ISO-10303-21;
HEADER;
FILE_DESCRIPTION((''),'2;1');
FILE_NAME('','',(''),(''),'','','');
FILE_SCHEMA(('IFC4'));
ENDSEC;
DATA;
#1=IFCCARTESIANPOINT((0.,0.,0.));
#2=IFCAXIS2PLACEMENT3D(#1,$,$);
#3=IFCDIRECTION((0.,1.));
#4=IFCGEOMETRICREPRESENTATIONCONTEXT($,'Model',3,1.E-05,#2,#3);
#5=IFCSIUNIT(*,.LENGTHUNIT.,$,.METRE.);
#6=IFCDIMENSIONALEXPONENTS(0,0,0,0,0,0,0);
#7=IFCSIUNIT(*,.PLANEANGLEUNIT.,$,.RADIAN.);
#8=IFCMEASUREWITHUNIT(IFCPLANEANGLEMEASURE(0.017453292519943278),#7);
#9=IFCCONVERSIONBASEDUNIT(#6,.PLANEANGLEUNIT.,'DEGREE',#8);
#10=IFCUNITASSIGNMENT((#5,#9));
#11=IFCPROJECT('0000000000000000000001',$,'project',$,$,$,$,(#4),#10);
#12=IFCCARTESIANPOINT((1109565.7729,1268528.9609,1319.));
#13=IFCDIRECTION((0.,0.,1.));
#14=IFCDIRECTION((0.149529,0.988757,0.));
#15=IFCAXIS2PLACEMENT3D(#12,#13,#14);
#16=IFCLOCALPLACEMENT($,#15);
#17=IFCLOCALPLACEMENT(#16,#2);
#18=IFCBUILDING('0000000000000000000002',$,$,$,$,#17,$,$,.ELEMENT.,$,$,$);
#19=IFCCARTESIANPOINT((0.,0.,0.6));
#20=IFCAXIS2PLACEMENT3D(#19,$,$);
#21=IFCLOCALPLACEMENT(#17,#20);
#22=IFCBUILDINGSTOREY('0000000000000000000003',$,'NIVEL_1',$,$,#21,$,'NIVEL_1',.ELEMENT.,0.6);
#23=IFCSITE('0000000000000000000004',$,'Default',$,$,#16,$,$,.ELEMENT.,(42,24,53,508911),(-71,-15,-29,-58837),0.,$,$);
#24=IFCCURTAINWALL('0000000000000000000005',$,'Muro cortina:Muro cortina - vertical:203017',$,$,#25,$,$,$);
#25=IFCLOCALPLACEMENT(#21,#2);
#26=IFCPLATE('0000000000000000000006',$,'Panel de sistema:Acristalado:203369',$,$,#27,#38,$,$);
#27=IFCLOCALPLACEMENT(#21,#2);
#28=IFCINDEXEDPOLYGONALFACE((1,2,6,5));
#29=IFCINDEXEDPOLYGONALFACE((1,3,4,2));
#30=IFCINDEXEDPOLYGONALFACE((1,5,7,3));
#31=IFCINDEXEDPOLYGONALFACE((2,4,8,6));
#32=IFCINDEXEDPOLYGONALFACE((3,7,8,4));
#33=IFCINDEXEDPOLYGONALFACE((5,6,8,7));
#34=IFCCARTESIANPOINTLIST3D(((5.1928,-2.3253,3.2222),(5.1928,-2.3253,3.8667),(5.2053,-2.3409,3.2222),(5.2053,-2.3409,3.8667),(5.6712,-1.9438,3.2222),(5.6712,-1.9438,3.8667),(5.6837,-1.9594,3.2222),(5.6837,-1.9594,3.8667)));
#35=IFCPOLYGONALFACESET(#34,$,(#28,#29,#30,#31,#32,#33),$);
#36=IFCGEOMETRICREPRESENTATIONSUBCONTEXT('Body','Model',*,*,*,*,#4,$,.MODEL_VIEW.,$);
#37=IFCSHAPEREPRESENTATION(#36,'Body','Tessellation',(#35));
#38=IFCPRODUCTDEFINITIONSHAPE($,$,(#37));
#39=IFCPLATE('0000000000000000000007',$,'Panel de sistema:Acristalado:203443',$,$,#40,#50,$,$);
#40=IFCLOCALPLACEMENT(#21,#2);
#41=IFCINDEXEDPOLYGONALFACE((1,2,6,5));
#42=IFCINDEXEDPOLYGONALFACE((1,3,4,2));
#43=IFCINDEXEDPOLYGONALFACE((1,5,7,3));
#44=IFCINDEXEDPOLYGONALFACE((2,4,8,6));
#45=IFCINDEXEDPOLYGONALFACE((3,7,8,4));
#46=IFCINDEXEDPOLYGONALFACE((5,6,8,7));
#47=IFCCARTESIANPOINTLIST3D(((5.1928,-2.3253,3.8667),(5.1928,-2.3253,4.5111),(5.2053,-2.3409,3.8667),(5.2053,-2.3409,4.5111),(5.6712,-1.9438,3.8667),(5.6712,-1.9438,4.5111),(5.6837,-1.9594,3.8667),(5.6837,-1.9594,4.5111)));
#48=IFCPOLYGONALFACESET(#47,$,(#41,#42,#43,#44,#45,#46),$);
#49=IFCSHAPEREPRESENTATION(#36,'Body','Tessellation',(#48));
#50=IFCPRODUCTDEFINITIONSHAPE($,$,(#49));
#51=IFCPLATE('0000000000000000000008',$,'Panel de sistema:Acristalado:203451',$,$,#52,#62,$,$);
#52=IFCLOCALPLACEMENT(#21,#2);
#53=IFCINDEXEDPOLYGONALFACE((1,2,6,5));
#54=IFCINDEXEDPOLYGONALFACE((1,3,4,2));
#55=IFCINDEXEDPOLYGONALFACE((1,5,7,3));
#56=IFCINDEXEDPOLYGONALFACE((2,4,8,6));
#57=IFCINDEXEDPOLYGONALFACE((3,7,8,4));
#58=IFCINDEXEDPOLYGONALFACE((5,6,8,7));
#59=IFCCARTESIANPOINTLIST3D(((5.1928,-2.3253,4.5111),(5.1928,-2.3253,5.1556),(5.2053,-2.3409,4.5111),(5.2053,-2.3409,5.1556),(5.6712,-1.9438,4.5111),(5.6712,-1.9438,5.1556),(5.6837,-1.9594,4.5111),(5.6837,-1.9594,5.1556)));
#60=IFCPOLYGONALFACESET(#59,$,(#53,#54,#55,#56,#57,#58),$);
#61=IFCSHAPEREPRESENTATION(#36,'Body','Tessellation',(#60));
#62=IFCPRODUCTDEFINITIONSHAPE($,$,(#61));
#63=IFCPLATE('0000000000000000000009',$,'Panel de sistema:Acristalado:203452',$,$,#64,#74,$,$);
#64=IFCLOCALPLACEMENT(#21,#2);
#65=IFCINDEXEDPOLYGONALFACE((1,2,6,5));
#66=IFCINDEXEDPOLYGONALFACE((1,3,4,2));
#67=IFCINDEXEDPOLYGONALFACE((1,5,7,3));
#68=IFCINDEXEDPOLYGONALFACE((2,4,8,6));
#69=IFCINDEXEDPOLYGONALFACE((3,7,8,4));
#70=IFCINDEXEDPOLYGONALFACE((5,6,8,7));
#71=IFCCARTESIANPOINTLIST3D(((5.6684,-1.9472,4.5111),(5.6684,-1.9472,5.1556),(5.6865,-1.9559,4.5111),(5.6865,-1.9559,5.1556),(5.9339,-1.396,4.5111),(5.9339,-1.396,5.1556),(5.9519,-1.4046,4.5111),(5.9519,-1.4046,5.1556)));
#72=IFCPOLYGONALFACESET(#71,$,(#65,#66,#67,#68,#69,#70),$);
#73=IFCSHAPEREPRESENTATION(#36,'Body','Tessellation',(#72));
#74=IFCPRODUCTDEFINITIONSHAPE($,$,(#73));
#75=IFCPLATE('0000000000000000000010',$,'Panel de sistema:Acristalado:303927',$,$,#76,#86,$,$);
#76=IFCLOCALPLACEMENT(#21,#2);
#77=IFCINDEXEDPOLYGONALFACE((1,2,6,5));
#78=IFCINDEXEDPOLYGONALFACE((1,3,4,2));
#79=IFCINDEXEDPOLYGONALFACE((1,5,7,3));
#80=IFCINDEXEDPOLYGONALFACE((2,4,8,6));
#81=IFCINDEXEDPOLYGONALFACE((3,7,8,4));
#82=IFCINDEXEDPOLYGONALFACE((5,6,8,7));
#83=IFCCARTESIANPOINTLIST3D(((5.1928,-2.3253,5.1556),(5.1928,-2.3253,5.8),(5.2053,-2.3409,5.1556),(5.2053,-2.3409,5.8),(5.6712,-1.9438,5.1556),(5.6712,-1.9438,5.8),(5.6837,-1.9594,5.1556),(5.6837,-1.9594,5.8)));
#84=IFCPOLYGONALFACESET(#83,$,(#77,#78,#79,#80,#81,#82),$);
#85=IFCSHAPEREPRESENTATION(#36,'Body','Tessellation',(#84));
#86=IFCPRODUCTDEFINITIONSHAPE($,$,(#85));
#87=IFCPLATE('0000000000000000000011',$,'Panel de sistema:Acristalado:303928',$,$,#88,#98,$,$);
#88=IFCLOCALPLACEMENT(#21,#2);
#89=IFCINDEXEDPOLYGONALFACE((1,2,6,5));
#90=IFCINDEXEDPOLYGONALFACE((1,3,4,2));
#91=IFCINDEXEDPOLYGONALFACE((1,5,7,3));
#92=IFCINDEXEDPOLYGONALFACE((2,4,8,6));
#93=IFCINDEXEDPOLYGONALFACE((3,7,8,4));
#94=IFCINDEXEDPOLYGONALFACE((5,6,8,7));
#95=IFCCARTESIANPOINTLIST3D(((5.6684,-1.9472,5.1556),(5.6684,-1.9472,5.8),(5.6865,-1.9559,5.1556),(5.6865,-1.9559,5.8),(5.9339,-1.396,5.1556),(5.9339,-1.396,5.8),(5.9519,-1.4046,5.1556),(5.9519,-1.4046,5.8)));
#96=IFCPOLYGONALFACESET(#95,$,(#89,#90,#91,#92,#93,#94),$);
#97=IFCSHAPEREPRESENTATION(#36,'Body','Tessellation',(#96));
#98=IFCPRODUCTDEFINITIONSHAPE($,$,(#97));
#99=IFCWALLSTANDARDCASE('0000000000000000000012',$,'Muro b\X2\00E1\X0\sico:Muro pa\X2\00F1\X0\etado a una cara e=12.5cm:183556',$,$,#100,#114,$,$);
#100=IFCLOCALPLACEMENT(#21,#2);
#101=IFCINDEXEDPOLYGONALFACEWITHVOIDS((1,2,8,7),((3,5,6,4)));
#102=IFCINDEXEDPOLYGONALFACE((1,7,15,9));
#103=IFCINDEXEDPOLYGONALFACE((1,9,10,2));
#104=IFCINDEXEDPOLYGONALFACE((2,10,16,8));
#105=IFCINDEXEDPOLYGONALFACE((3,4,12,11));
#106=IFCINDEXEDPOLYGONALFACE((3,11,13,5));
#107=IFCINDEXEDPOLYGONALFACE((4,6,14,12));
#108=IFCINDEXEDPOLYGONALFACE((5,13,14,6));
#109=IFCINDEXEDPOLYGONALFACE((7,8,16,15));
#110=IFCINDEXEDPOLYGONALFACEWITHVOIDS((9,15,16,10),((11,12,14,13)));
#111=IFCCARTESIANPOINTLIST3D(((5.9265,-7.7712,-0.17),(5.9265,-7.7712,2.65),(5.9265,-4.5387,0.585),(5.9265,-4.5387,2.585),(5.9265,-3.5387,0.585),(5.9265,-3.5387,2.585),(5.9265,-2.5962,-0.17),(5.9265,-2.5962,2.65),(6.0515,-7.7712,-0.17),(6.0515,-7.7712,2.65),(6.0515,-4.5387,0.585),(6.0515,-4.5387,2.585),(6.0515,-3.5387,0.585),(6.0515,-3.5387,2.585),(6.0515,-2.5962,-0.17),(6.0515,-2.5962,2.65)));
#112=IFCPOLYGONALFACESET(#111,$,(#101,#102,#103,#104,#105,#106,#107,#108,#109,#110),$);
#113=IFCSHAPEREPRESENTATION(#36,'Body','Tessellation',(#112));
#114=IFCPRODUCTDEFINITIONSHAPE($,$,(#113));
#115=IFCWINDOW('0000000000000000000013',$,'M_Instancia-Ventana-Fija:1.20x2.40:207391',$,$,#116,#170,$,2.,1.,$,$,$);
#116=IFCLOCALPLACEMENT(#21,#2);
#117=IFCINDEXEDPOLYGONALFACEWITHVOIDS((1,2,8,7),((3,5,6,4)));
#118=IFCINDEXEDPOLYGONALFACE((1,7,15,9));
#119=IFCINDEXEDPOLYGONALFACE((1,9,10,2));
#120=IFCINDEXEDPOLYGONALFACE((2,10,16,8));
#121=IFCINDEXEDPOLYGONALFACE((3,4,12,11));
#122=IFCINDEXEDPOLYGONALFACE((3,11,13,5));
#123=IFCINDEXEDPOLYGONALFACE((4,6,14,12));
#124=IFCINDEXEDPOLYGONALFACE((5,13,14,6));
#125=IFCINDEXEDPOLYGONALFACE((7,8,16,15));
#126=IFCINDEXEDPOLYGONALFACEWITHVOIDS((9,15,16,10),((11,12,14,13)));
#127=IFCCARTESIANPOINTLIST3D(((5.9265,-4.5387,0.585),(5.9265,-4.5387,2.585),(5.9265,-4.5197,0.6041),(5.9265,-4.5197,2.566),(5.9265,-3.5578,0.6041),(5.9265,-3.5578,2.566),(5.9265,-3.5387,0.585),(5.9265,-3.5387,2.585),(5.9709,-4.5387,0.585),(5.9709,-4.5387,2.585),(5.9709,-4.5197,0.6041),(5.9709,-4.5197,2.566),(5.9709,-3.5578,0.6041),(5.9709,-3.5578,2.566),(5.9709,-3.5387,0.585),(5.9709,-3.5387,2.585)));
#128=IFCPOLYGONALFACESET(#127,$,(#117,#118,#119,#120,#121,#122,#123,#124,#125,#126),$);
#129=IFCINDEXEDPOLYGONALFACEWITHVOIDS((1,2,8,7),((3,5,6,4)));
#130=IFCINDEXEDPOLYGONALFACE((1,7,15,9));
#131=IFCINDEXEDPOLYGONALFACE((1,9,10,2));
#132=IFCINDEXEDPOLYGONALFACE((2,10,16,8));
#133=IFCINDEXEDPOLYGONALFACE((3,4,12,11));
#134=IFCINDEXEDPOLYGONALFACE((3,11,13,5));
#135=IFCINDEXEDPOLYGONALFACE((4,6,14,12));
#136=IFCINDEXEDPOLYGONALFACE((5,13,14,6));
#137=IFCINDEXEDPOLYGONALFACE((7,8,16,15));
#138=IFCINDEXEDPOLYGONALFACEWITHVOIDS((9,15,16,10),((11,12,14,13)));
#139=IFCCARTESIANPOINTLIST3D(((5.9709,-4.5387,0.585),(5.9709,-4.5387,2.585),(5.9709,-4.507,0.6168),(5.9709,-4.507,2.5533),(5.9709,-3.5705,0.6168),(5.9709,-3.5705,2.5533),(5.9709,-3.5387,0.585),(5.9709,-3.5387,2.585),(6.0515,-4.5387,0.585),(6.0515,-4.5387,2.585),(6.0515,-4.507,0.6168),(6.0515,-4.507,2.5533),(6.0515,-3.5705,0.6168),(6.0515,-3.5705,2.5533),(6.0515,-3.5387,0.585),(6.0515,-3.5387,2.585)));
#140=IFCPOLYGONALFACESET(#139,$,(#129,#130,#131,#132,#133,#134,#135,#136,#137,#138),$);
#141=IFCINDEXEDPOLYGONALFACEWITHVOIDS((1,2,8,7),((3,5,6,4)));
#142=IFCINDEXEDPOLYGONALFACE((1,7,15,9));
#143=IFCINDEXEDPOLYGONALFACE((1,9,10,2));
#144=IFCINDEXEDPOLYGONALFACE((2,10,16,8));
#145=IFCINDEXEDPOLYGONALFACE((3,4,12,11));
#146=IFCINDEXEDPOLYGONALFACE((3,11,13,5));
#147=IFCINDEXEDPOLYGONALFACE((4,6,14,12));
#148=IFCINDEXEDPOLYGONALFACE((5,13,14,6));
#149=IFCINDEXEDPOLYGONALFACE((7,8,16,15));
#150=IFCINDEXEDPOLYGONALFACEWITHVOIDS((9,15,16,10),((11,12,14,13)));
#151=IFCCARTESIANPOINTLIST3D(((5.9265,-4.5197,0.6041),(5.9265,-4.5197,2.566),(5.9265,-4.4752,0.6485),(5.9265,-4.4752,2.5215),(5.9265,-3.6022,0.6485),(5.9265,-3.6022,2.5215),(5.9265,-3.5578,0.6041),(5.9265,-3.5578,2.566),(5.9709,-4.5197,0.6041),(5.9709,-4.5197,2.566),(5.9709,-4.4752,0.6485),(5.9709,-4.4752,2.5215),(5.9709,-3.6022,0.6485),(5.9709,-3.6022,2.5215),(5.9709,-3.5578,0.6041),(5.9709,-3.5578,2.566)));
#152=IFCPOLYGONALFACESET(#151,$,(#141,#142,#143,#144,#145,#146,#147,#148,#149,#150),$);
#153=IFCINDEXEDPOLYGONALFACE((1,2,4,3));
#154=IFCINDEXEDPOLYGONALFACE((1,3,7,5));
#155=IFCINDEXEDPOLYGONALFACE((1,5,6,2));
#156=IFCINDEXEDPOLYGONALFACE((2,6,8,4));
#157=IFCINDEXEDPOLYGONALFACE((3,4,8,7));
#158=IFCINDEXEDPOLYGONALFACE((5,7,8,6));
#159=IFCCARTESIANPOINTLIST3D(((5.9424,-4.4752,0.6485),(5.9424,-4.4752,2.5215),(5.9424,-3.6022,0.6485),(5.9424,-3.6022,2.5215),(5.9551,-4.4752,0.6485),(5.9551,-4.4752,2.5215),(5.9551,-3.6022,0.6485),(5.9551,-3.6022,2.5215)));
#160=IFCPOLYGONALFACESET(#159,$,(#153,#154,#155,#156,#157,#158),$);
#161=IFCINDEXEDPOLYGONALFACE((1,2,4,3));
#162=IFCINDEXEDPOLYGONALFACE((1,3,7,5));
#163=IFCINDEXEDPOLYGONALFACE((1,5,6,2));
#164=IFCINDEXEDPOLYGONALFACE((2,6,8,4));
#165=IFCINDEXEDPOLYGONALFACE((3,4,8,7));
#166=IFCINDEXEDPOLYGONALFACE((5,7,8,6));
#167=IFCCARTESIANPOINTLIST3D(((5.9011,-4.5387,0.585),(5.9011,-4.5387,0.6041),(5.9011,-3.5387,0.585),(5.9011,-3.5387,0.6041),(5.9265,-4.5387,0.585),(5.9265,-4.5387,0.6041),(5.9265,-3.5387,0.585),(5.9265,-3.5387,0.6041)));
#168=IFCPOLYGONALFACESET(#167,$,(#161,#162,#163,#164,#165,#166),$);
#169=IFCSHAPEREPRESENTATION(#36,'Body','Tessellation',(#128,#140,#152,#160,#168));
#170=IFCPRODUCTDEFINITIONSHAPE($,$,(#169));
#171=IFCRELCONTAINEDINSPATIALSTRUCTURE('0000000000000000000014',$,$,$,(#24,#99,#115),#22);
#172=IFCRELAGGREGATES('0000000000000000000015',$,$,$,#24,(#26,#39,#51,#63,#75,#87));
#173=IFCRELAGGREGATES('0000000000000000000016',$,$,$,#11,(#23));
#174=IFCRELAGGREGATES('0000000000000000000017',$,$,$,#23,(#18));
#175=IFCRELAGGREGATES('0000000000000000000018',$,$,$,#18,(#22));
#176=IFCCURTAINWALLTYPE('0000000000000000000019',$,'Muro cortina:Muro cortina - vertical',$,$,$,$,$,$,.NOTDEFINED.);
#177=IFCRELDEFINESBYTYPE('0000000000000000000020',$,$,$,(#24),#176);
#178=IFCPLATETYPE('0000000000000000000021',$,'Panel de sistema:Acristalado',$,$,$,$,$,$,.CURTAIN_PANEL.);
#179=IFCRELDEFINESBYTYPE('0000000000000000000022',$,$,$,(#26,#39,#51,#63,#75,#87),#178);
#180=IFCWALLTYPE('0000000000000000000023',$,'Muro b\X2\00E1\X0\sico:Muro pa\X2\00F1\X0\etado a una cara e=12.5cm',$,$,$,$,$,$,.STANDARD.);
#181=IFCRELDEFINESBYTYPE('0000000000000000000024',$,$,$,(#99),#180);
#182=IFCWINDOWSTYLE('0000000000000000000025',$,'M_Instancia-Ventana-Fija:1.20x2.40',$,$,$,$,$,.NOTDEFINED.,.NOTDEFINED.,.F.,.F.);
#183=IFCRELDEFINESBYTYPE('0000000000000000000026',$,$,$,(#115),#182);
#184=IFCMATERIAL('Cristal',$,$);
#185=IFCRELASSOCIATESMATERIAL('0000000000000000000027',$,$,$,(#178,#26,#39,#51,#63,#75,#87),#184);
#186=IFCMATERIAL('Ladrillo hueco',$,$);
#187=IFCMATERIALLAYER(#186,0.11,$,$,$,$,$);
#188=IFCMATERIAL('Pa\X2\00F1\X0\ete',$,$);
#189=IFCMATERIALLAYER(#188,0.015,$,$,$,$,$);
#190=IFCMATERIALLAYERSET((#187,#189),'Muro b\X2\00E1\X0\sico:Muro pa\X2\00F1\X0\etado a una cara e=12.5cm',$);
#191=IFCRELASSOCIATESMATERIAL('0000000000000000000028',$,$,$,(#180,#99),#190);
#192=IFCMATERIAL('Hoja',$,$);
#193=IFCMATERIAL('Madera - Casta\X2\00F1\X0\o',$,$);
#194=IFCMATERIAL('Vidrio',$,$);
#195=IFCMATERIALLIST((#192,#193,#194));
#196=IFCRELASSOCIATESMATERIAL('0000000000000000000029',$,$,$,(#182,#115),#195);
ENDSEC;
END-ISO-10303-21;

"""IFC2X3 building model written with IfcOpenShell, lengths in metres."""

from ifc_helpers import new_model, entity, si_unit, converted_unit, direction, frame, frame_2d, origin, origin_2d_with_axis, place, context, subcontext, project, spatial, polyline, rectangle, outline, extrude, source, transform, mapped, material, material_list, layer, layer_set, layer_usage, type_object, type_shapes, element, fill, aggregate, save


model = new_model("IFC2X3")

# Units and contexts
model_context = context("Model", 3, precision=1e-05, world=origin(), true_north=direction((0.0, 1.0)))
body_context = subcontext(model_context, "Body", "Model", "MODEL_VIEW")
ifc_project = project(units=[si_unit("LENGTHUNIT", "METRE"), converted_unit("PLANEANGLEUNIT", "DEGREE", entity("IfcPlaneAngleMeasure", 0.017453292519943278), si_unit("PLANEANGLEUNIT", "RADIAN"), dimensions=[0, 0, 0, 0, 0, 0, 0])], contexts=[model_context])

# Site, building, storey
site_placement = place(None, frame((1109565.7729, 1268528.9609, 1319.0), z_axis=(0.0, 0.0, 1.0), x_axis=(0.149529, 0.988757, 0.0)))
site = spatial("IfcSite", under=ifc_project, at=site_placement, Name="Default", CompositionType="ELEMENT", RefLatitude=(42, 24, 53, 508911), RefLongitude=(-71, -15, -29, -58837), RefElevation=0.0)
building_placement = place(site_placement, origin())
building = spatial("IfcBuilding", under=site, at=building_placement, CompositionType="ELEMENT")
storey_placement = place(building_placement, frame((0.0, 0.0, 0.6)))
storey = spatial("IfcBuildingStorey", under=building, at=storey_placement, Name="NIVEL_1", LongName="NIVEL_1", CompositionType="ELEMENT", Elevation=0.6)

# Curtain wall, plates
curtain_wall_type = type_object("IfcCurtainWallType", Name="Muro cortina:Muro cortina - vertical", PredefinedType="NOTDEFINED")
curtain_wall_1_placement = place(storey_placement, frame((0.0, 0.0, -0.6)))
curtain_wall_1 = element("IfcCurtainWall", 1, at=curtain_wall_1_placement, inside=storey, type_object=curtain_wall_type, Name="Muro cortina:Muro cortina - vertical:203017")
ifc_material_1 = material(Name="Cristal")
plate_type_1 = type_object("IfcPlateType", Name="Panel de sistema:Acristalado", PredefinedType="CURTAIN_PANEL", material=ifc_material_1)
shared_shape_1 = source(origin(), body_context, "Body", "SweptSolid", [
    extrude(rectangle(XDim=0.02, YDim=0.6119, at=frame_2d((0.0, 0.0), x_axis=(1.0, 0.0))), frame((0.0, 0.0, 0.0), z_axis=(0.0, 0.0, 1.0), x_axis=(0.0, 1.0, 0.0)), (0.0, 0.0, 1.0), 0.6444),
])
type_shapes(plate_type_1, [shared_shape_1])
plate_1_placement = place(curtain_wall_1_placement, frame((5.4383, -2.1423, 3.8222), z_axis=(0.0, 0.0, 1.0), x_axis=(0.781832, 0.62349, 0.0)))
plate_1 = element("IfcPlate", 2, at=plate_1_placement, type_object=plate_type_1, material=ifc_material_1, Name="Panel de sistema:Acristalado:203369", context=body_context, shape_type="MappedRepresentation", body=[
    mapped(shared_shape_1, transform((0.0, 0.0, 0.0), scale=1.0)),
])
plate_2_placement = place(curtain_wall_1_placement, frame((5.4383, -2.1423, 4.4667), z_axis=(0.0, 0.0, 1.0), x_axis=(0.781832, 0.62349, 0.0)))
plate_2 = element("IfcPlate", 3, at=plate_2_placement, type_object=plate_type_1, material=ifc_material_1, Name="Panel de sistema:Acristalado:203443", context=body_context, shape_type="MappedRepresentation", body=[
    mapped(shared_shape_1, transform((0.0, 0.0, 0.0), scale=1.0)),
])
plate_3_placement = place(curtain_wall_1_placement, frame((5.4383, -2.1423, 5.1111), z_axis=(0.0, 0.0, 1.0), x_axis=(0.781832, 0.62349, 0.0)))
plate_3 = element("IfcPlate", 4, at=plate_3_placement, type_object=plate_type_1, material=ifc_material_1, Name="Panel de sistema:Acristalado:203451", context=body_context, shape_type="MappedRepresentation", body=[
    mapped(shared_shape_1, transform((0.0, 0.0, 0.0), scale=1.0)),
])
plate_4_placement = place(curtain_wall_1_placement, frame((5.8102, -1.6759, 5.1111), z_axis=(0.0, 0.0, 1.0), x_axis=(0.433884, 0.900969, 0.0)))
plate_4 = element("IfcPlate", 5, at=plate_4_placement, type_object=plate_type_1, material=ifc_material_1, Name="Panel de sistema:Acristalado:203452", context=body_context, shape_type="MappedRepresentation", body=[
    mapped(shared_shape_1, transform((0.0, 0.0, 0.0), scale=1.0)),
])
plate_5_placement = place(curtain_wall_1_placement, frame((5.4383, -2.1423, 5.7556), z_axis=(0.0, 0.0, 1.0), x_axis=(0.781832, 0.62349, 0.0)))
plate_5 = element("IfcPlate", 6, at=plate_5_placement, type_object=plate_type_1, material=ifc_material_1, Name="Panel de sistema:Acristalado:303927", context=body_context, shape_type="MappedRepresentation", body=[
    mapped(shared_shape_1, transform((0.0, 0.0, 0.0), scale=1.0)),
])
plate_6_placement = place(curtain_wall_1_placement, frame((5.8102, -1.6759, 5.7556), z_axis=(0.0, 0.0, 1.0), x_axis=(0.433884, 0.900969, 0.0)))
plate_6 = element("IfcPlate", 7, at=plate_6_placement, type_object=plate_type_1, material=ifc_material_1, Name="Panel de sistema:Acristalado:303928", context=body_context, shape_type="MappedRepresentation", body=[
    mapped(shared_shape_1, transform((0.0, 0.0, 0.0), scale=1.0)),
])
aggregate(curtain_wall_1, [plate_1, plate_2, plate_3, plate_4, plate_5, plate_6])

# Wall, opening, window
ifc_material_2 = material(Name="Ladrillo hueco")
ifc_layer_1 = layer(ifc_material_2, 0.11)
ifc_material_3 = material(Name="Pañete")
ifc_layer_2 = layer(ifc_material_3, 0.015)
ifc_layer_set_1 = layer_set([ifc_layer_1, ifc_layer_2], Name="Muro básico:Muro pañetado a una cara e=12.5cm")
ifc_layer_usage_1 = layer_usage(ifc_layer_set_1, "AXIS2", "POSITIVE", -0.0625)
wall_type_1 = type_object("IfcWallType", Name="Muro básico:Muro pañetado a una cara e=12.5cm", PredefinedType="STANDARD", material=ifc_layer_set_1)
wall_1_placement = place(storey_placement, frame((5.989, -7.7712, -0.17), z_axis=(0.0, 0.0, 1.0), x_axis=(0.0, 1.0, 0.0)))
wall_1 = element("IfcWallStandardCase", 8, at=wall_1_placement, inside=storey, type_object=wall_type_1, material=ifc_layer_usage_1, Name="Muro básico:Muro pañetado a una cara e=12.5cm:183556", context=body_context, shape_type="SweptSolid", body=[
    extrude(rectangle(XDim=5.175, YDim=0.125, at=frame_2d((2.5875, 0.0), x_axis=(-1.0, 0.0))), origin(), (0.0, 0.0, 1.0), 2.82),
])
opening_1_placement = place(wall_1_placement, frame((3.2325, -0.0625, 0.755)))
opening_1 = element("IfcOpeningElement", 9, at=opening_1_placement, cuts=wall_1, ObjectType="Opening", context=body_context, shape_type="SweptSolid", body=[
    extrude(rectangle(XDim=2.0, YDim=1.0, at=frame_2d((1.0, 0.5), x_axis=(-1.0, 0.0))), frame((0.0, 0.0, 0.0), z_axis=(0.0, 1.0, 0.0), x_axis=(0.0, 0.0, 1.0)), (0.0, 0.0, 1.0), 0.125),
])
ifc_material_4 = material(Name="Hoja")
ifc_material_5 = material(Name="Madera - Castaño")
ifc_material_6 = material(Name="Vidrio")
ifc_material_list = material_list([ifc_material_4, ifc_material_5, ifc_material_6])
window_style = type_object("IfcWindowStyle", Name="M_Instancia-Ventana-Fija:1.20x2.40", ConstructionType="NOTDEFINED", OperationType="NOTDEFINED", ParameterTakesPrecedence=False, Sizeable=False, material=ifc_material_list)
shared_shape_2 = source(origin(), body_context, "Body", "SweptSolid", [
    extrude(outline(polyline([(-1.0, -0.5), (1.0, -0.5), (1.0, 0.5), (-1.0, 0.5), (-1.0, -0.5)]), holes=[polyline([(-0.9809, -0.4809), (-0.9809, 0.481), (0.981, 0.481), (0.981, -0.4809), (-0.9809, -0.4809)])]), frame((0.5, 0.0806, 1.0), z_axis=(0.0, 1.0, 0.0), x_axis=(0.0, 0.0, -1.0)), (0.0, 0.0, 1.0), 0.0444),
    extrude(outline(polyline([(-0.5, -1.0), (0.5, -1.0), (0.5, 1.0), (-0.5, 1.0), (-0.5, -1.0)]), holes=[polyline([(-0.4683, -0.9682), (-0.4683, 0.9683), (0.4682, 0.9683), (0.4682, -0.9682), (-0.4683, -0.9682)])]), frame((0.5, 0.0, 1.0), z_axis=(0.0, 1.0, 0.0), x_axis=(1.0, 0.0, 0.0)), (0.0, 0.0, 1.0), 0.0806),
    extrude(outline(polyline([(-0.4809, -0.981), (0.4809, -0.981), (0.4809, 0.981), (-0.4809, 0.981), (-0.4809, -0.981)]), holes=[polyline([(-0.4365, -0.9365), (-0.4365, 0.9365), (0.4365, 0.9365), (0.4365, -0.9365), (-0.4365, -0.9365)])]), frame((0.5, 0.0806, 1.0), z_axis=(0.0, 1.0, 0.0), x_axis=(1.0, 0.0, 0.0)), (0.0, 0.0, 1.0), 0.0444),
    extrude(rectangle(XDim=0.0127, YDim=0.873, at=frame_2d((0.0, 0.0), x_axis=(1.0, 0.0))), frame((0.5, 0.1028, 0.0635), z_axis=(0.0, 0.0, 1.0), x_axis=(0.0, 1.0, 0.0)), (0.0, 0.0, 1.0), 1.873),
    extrude(rectangle(XDim=0.0254, YDim=1.0, at=origin_2d_with_axis()), frame((0.5, 0.1377, 0.0), z_axis=(0.0, 0.0, 1.0), x_axis=(0.0, -1.0, 0.0)), (0.0, 0.0, 1.0), 0.019),
])
type_shapes(window_style, [shared_shape_2])
window_placement = place(opening_1_placement, origin())
window = element("IfcWindow", 10, at=window_placement, inside=storey, type_object=window_style, material=ifc_material_list, Name="M_Instancia-Ventana-Fija:1.20x2.40:207391", OverallHeight=2.0, OverallWidth=1.0, context=body_context, shape_type="MappedRepresentation", body=[
    mapped(shared_shape_2, transform((0.0, 0.0, 0.0), scale=1.0)),
])
fill(opening_1, window)

save(model, "model.ifc")
